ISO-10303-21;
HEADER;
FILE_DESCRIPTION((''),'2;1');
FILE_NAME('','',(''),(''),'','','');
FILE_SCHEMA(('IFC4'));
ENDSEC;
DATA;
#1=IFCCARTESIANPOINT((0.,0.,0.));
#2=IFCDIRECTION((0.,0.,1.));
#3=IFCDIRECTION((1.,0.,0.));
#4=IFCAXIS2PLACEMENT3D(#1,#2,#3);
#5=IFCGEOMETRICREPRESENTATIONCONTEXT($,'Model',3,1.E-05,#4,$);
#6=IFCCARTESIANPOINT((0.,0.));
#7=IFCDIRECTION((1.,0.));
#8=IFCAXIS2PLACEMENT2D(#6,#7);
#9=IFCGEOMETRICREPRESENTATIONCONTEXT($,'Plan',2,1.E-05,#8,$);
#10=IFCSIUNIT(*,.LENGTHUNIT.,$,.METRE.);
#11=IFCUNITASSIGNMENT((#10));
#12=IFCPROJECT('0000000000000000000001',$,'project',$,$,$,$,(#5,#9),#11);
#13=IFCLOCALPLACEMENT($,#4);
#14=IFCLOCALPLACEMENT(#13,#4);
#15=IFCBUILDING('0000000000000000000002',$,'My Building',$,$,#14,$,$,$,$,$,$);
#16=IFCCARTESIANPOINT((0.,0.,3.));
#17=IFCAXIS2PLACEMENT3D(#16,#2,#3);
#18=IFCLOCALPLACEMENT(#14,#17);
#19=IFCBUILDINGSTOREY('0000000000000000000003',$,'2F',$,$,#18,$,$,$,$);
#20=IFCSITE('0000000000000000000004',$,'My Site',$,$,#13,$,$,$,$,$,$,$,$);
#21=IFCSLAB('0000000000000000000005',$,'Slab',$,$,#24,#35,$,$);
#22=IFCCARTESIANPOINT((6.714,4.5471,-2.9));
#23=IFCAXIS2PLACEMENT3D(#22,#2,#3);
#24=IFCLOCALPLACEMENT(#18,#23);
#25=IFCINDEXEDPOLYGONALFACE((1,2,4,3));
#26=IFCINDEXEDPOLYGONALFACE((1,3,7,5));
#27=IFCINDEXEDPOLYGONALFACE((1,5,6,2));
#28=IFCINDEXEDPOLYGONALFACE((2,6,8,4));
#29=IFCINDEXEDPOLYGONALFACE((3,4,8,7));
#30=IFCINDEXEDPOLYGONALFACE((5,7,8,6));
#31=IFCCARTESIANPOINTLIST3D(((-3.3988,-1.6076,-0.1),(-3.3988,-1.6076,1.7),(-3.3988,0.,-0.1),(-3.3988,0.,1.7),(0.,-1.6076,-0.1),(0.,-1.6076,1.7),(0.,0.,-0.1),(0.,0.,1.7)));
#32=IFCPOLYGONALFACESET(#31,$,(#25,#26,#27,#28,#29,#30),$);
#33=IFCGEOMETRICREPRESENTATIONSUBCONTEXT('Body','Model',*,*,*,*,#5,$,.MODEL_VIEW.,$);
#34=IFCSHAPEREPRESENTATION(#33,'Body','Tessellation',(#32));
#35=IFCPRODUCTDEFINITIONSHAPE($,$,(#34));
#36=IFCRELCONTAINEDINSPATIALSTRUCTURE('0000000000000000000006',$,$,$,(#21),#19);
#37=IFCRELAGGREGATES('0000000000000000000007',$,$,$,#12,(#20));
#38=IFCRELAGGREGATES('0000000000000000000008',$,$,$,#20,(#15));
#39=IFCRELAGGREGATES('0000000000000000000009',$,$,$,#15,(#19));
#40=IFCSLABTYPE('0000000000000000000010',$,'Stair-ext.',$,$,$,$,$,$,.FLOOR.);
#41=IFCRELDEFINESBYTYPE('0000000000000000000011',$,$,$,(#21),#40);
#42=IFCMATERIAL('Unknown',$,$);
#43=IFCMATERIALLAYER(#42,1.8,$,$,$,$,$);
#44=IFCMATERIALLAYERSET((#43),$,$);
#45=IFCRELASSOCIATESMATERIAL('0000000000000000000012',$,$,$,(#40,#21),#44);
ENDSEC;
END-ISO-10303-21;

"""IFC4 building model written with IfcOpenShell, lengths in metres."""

from ifc_helpers import new_model, si_unit, frame, origin_with_axes, origin_2d_with_axis, place, context, subcontext, project, spatial, indexed_curve, outline, extrude, material, layer, layer_set, layer_usage, type_object, element, save


model = new_model("IFC4")

# Units and contexts
model_context = context("Model", 3, precision=1e-05, world=origin_with_axes())
plan_context = context("Plan", 2, precision=1e-05, world=origin_2d_with_axis())
body_context_1 = subcontext(model_context, "Body", "Model", "MODEL_VIEW")
ifc_project = project(units=[si_unit("LENGTHUNIT", "METRE")], contexts=[model_context, plan_context])

# Site, building, storey
site_placement = place(None, origin_with_axes())
site = spatial("IfcSite", under=ifc_project, at=site_placement, Name="My Site")
building_placement = place(site_placement, origin_with_axes())
building = spatial("IfcBuilding", under=site, at=building_placement, Name="My Building")
storey_placement = place(building_placement, frame((0.0, 0.0, 3.0), z_axis=(0.0, 0.0, 1.0), x_axis=(1.0, 0.0, 0.0)))
storey = spatial("IfcBuildingStorey", under=building, at=storey_placement, Name="2F")

# Shared definitions
ifc_material = material(Name="Unknown")

# Slab
ifc_layer_1 = layer(ifc_material, 1.8)
ifc_layer_set_1 = layer_set([ifc_layer_1])
ifc_layer_usage_1 = layer_usage(ifc_layer_set_1, "AXIS3", "POSITIVE", -0.1)
slab_type = type_object("IfcSlabType", Name="Stair-ext.", PredefinedType="FLOOR", material=ifc_layer_set_1)
slab_placement = place(storey_placement, frame((6.714, 4.5471, -2.9), z_axis=(0.0, 0.0, 1.0), x_axis=(1.0, 0.0, 0.0)))
element("IfcSlab", 1, at=slab_placement, inside=storey, type_object=slab_type, material=ifc_layer_usage_1, Name="Slab", context=body_context_1, shape_type="SweptSolid", body=[
    extrude(outline(indexed_curve([(0.0, 0.0), (0.0, -1.6076), (-3.3988, -1.6076), (-3.3988, 0.0), (0.0, 0.0)])), frame((0.0, 0.0, -0.1), z_axis=(0.0, 0.0, 1.0), x_axis=(1.0, 0.0, 0.0)), (0.0, 0.0, 1.0), 1.8),
])

save(model, "model.ifc")
